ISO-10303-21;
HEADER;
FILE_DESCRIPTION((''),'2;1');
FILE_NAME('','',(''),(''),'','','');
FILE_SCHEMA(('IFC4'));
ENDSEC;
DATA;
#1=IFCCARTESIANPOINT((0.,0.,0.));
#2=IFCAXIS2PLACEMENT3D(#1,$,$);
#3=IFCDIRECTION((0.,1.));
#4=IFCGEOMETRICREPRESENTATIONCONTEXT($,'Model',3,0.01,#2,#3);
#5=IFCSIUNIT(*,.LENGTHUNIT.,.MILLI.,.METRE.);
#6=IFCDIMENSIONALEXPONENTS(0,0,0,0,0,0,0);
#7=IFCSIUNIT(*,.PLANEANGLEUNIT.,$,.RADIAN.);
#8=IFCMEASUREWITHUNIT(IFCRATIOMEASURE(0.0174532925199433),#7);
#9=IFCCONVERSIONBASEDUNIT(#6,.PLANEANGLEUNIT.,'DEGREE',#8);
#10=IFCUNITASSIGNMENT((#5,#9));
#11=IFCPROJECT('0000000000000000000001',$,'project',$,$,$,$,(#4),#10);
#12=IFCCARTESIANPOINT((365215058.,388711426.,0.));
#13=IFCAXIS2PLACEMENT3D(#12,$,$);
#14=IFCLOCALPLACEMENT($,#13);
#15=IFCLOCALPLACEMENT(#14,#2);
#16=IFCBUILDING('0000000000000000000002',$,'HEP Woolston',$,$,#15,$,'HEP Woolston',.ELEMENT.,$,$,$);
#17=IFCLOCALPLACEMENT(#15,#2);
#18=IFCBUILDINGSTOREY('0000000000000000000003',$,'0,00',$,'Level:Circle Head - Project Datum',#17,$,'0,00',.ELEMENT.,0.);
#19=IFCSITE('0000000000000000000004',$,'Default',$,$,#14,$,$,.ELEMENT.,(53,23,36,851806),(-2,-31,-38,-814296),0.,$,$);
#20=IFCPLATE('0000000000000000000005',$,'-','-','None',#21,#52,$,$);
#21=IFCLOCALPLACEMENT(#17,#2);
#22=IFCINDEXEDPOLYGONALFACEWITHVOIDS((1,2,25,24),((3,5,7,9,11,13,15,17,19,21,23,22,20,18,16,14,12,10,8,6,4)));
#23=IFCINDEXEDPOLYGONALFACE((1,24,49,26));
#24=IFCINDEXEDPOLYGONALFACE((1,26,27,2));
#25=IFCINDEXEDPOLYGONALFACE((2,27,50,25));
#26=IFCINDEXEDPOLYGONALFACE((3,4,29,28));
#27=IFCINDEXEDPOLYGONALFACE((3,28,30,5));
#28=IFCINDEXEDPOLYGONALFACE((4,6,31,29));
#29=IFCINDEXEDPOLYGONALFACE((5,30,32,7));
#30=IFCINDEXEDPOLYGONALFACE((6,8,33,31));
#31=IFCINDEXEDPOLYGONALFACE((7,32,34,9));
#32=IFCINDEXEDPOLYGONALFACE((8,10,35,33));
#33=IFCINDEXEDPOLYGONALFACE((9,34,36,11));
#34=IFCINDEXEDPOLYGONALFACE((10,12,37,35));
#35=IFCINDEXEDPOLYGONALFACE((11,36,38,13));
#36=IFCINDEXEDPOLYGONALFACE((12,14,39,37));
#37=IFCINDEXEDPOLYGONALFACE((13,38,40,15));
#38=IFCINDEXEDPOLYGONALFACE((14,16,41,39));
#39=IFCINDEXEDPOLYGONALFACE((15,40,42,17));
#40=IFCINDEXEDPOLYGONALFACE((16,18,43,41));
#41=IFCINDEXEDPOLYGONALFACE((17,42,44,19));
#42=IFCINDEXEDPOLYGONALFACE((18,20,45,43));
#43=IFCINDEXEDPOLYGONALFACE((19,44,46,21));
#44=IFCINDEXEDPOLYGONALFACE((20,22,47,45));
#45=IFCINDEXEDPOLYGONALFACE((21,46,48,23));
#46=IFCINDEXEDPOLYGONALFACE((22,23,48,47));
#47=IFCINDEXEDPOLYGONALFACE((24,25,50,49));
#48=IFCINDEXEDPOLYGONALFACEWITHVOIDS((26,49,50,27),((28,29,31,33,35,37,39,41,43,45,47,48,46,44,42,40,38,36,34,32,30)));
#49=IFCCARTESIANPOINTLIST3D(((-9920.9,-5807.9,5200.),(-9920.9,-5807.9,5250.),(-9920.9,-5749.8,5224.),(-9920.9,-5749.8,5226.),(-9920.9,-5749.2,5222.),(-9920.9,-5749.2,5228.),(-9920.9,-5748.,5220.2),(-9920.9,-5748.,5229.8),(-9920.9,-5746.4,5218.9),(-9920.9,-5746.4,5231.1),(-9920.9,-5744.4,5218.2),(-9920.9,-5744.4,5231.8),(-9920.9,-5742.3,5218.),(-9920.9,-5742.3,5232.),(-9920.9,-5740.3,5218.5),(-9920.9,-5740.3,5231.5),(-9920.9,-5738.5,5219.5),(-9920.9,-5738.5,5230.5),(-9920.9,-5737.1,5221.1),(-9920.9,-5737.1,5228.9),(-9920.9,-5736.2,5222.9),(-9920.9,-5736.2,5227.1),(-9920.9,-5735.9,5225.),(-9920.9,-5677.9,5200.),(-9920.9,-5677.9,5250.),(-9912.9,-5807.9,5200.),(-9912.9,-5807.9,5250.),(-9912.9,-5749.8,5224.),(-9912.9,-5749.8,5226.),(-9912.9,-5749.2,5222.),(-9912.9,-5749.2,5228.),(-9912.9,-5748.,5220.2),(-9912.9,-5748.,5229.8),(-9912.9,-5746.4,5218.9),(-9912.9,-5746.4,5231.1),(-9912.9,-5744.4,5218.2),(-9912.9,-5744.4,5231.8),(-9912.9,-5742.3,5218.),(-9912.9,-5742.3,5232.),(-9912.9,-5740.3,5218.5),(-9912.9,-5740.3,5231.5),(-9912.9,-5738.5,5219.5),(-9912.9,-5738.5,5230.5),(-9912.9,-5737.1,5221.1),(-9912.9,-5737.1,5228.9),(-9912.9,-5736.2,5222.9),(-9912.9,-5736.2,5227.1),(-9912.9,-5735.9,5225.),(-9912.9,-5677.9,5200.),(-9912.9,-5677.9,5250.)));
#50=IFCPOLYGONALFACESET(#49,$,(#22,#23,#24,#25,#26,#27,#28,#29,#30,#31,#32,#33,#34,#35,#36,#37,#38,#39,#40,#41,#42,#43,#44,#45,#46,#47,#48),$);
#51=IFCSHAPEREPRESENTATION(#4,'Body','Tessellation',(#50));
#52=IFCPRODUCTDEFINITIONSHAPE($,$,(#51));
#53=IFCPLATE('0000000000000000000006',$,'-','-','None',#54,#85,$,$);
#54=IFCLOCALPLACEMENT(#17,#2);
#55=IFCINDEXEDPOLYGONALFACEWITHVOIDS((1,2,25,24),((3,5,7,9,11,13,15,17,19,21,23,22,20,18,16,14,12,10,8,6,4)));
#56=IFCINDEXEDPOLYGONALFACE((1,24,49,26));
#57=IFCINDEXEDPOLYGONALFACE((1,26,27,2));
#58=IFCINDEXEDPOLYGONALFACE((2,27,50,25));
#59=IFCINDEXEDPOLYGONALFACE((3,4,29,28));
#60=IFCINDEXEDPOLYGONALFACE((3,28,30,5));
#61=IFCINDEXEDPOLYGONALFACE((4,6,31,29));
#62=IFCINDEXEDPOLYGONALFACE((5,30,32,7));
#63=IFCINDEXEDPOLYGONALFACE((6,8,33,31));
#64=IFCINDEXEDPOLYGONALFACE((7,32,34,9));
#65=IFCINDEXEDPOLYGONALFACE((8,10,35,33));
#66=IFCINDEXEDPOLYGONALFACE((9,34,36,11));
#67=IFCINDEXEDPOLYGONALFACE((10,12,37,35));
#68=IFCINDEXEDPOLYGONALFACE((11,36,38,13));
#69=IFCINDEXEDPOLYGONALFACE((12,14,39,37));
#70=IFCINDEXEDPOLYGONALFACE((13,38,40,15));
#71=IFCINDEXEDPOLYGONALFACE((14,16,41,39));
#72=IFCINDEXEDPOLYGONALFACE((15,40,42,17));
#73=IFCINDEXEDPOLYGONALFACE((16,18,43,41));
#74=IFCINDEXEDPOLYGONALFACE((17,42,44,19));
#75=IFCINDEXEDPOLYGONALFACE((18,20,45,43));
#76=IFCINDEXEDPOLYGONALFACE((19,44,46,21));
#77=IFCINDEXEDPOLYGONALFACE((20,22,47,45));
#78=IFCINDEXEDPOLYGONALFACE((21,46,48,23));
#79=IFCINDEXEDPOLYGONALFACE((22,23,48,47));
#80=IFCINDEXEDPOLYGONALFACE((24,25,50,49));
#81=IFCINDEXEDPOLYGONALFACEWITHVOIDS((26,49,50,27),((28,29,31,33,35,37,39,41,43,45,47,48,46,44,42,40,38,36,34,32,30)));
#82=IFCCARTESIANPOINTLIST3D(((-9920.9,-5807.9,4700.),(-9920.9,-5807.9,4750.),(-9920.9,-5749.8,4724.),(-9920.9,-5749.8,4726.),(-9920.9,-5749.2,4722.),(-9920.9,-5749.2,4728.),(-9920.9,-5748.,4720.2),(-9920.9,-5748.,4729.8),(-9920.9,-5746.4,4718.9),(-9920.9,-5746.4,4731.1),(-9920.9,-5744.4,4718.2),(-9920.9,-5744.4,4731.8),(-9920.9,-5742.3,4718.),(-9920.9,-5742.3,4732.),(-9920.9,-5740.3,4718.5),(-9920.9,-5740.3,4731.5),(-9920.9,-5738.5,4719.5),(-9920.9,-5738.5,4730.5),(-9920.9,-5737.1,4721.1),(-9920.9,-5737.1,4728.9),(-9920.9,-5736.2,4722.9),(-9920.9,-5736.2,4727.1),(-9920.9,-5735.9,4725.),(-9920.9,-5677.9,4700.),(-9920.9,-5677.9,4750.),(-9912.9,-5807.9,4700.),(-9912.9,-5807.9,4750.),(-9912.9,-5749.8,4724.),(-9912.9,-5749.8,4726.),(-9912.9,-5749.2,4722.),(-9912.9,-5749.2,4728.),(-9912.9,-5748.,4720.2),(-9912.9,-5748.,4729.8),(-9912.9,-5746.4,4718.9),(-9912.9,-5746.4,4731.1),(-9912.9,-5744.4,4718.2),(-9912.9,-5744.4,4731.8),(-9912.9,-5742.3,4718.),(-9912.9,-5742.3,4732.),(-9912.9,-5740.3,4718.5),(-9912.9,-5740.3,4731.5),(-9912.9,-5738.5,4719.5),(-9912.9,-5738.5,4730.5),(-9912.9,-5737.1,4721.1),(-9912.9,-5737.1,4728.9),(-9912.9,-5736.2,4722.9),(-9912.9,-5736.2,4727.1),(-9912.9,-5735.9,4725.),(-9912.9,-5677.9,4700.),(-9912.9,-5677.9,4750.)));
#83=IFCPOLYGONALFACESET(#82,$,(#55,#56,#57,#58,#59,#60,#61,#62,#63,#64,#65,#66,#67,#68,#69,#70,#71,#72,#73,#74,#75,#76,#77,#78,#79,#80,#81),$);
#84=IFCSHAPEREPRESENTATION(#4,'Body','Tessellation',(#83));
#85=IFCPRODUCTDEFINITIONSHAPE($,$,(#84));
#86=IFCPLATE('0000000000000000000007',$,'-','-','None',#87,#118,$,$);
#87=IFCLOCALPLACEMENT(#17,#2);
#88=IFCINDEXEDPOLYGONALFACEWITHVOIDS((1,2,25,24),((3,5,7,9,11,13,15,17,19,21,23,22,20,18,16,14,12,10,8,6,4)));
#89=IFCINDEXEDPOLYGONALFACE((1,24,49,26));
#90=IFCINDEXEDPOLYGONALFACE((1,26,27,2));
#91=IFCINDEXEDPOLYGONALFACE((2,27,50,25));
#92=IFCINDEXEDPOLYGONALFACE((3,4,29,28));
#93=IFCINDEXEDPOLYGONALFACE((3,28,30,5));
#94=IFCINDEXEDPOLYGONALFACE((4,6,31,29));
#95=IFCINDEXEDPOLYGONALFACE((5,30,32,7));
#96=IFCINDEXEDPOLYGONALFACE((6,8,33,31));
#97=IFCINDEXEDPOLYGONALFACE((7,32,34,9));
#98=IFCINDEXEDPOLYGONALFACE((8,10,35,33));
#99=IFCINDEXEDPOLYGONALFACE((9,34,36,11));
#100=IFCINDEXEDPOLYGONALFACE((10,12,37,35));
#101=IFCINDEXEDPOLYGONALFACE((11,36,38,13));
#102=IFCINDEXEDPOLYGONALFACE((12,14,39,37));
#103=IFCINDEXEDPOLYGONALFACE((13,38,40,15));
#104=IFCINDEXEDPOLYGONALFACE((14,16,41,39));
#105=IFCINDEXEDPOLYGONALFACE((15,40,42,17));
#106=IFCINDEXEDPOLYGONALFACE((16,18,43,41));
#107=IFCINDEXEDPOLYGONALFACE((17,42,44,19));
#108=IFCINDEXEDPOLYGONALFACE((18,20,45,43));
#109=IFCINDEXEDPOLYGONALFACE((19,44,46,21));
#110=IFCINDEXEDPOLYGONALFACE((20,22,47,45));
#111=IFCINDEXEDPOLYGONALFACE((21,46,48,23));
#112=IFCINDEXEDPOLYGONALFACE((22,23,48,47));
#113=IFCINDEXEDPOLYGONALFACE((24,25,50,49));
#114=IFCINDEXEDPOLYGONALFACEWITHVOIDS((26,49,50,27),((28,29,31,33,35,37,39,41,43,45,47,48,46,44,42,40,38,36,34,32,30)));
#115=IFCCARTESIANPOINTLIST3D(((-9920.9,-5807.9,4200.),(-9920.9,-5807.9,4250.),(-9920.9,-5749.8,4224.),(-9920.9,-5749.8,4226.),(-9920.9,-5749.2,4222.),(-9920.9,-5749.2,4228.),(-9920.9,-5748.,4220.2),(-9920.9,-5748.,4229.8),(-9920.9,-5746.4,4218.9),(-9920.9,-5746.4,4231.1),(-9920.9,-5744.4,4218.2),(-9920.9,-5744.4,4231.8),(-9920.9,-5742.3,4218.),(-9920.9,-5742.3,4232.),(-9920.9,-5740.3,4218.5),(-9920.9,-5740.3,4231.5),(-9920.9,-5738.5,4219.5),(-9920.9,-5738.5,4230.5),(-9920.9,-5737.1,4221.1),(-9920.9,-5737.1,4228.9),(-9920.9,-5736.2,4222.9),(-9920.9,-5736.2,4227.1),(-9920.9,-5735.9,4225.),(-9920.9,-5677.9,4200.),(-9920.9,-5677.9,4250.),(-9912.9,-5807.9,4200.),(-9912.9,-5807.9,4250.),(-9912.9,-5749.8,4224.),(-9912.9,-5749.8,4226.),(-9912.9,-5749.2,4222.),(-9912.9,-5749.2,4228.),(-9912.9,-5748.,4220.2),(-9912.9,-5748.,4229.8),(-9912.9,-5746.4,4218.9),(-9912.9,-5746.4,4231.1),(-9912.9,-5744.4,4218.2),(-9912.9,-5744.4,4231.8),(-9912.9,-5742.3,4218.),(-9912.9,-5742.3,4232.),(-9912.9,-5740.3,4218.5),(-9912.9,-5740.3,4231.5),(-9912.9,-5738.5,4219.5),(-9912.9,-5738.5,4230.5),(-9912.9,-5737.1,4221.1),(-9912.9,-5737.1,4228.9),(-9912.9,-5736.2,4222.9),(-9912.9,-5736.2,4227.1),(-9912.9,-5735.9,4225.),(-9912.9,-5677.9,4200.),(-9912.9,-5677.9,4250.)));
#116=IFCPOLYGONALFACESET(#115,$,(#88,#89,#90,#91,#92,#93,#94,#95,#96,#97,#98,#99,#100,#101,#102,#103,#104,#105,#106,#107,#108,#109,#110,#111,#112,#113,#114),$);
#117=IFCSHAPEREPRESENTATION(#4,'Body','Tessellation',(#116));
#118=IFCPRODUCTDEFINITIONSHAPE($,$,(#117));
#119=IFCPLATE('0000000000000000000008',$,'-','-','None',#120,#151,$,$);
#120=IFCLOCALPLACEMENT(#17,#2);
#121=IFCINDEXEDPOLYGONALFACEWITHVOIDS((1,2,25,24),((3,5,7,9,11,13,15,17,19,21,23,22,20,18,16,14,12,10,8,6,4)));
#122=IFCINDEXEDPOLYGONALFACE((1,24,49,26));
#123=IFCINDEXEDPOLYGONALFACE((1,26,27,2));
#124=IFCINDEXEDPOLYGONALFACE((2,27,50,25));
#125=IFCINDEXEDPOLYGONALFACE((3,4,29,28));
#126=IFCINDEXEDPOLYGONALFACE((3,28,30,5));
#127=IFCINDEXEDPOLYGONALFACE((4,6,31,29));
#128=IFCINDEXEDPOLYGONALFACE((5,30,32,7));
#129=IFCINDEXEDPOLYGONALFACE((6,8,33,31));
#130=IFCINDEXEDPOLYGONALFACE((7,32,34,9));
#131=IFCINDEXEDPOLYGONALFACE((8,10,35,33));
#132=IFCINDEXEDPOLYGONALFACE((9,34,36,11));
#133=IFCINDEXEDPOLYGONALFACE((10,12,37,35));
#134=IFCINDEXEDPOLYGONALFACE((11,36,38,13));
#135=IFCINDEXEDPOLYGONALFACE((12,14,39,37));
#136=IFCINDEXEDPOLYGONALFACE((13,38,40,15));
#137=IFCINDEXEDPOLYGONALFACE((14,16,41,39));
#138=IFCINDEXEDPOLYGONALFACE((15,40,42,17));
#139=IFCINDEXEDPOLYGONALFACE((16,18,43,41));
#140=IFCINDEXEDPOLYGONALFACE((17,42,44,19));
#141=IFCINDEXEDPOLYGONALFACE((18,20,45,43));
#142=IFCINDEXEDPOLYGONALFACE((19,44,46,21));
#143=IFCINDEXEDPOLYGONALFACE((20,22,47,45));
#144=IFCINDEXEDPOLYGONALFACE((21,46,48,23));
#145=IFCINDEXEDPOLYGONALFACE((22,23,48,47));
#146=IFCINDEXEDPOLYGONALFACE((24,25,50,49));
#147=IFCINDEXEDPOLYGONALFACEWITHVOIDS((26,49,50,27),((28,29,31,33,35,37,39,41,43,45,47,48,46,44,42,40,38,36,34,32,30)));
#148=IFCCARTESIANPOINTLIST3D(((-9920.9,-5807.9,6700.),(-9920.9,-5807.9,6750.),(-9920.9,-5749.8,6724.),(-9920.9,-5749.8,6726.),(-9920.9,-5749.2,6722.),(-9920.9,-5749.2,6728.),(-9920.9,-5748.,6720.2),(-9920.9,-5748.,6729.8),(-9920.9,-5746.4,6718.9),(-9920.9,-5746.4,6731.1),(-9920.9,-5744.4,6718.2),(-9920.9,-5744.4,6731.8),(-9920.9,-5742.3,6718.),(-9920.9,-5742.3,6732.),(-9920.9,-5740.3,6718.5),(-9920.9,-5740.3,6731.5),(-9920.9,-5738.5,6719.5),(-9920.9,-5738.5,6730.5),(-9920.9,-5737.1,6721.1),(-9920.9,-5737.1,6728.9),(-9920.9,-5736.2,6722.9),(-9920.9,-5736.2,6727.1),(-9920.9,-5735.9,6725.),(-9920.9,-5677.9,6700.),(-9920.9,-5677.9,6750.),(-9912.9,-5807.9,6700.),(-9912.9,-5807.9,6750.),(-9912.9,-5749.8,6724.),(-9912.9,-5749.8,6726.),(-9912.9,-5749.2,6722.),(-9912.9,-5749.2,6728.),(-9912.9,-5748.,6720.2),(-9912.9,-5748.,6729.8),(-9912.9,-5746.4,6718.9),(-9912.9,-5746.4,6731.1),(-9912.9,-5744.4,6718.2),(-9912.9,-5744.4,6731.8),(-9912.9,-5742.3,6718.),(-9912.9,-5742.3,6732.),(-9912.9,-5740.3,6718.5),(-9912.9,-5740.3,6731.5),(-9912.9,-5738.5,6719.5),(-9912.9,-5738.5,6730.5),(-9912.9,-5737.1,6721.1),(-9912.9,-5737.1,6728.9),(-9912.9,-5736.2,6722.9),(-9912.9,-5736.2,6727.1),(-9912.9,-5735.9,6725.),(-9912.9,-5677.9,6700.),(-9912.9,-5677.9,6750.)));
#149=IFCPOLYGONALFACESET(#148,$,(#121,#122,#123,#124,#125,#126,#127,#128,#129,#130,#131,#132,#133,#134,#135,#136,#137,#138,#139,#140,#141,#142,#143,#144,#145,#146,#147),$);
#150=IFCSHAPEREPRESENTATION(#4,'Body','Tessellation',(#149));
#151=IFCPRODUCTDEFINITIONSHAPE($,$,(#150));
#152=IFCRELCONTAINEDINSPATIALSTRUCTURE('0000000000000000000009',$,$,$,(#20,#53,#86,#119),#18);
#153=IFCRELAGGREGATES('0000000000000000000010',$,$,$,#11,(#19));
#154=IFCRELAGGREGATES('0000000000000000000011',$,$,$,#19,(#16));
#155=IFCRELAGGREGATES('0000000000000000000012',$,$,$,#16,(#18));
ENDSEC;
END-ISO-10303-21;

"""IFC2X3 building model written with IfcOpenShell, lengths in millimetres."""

from ifc_helpers import new_model, entity, si_unit, converted_unit, direction, frame, origin, origin_with_axes, origin_2d_with_axis, place, context, project, spatial, polyline, circle, outline, extrude, element, save


model = new_model("IFC2X3")

# Units and contexts
model_context = context("Model", 3, precision=0.01, world=origin(), true_north=direction((0.0, 1.0)))
ifc_project = project(units=[si_unit("LENGTHUNIT", "METRE", prefix="MILLI"), converted_unit("PLANEANGLEUNIT", "DEGREE", entity("IfcRatioMeasure", 0.0174532925199433), si_unit("PLANEANGLEUNIT", "RADIAN"), dimensions=[0, 0, 0, 0, 0, 0, 0])], contexts=[model_context])

# Site, building, storey
site_placement = place(None, frame((365215058.0, 388711426.0, 0.0)))
site = spatial("IfcSite", under=ifc_project, at=site_placement, Name="Default", CompositionType="ELEMENT", RefLatitude=(53, 23, 36, 851806), RefLongitude=(-2, -31, -38, -814296), RefElevation=0.0)
building_placement = place(site_placement, origin())
building = spatial("IfcBuilding", under=site, at=building_placement, Name="HEP Woolston", LongName="HEP Woolston", CompositionType="ELEMENT")
storey_placement = place(building_placement, origin())
storey = spatial("IfcBuildingStorey", under=building, at=storey_placement, Name="0,00", ObjectType="Level:Circle Head - Project Datum", LongName="0,00", CompositionType="ELEMENT", Elevation=0.0)

# Plates, openings
plate_1_placement = place(storey_placement, frame((-9920.9, -5807.9, 5250.0), z_axis=(1.0, 0.0, 0.0), x_axis=(0.0, 1.0, 0.0)))
plate_1 = element("IfcPlate", 1, at=plate_1_placement, inside=storey, Name="-", Description="-", ObjectType="None", context=model_context, shape_type="SweptSolid", body=[
    extrude(outline(polyline([(0.0, -50.0), (130.0, -50.0), (130.0, 0.0), (0.0, 0.0), (0.0, -50.0)])), origin_with_axes(), (0.0, 0.0, 1.0), 8.0),
])
opening_1_placement = place(plate_1_placement, frame((65.0, -25.0, 8.5), z_axis=(0.0, 0.0, -1.0), x_axis=(1.0, 0.0, 0.0)))
element("IfcOpeningElement", 2, at=opening_1_placement, cuts=plate_1, ObjectType="Opening", context=model_context, shape_type="SweptSolid", body=[
    extrude(circle(Radius=7.0, at=origin_2d_with_axis()), origin(), (0.0, 0.0, 1.0), 9.0),
])
plate_2_placement = place(storey_placement, frame((-9920.9, -5807.9, 4750.0), z_axis=(1.0, 0.0, 0.0), x_axis=(0.0, 1.0, 0.0)))
plate_2 = element("IfcPlate", 3, at=plate_2_placement, inside=storey, Name="-", Description="-", ObjectType="None", context=model_context, shape_type="SweptSolid", body=[
    extrude(outline(polyline([(0.0, -50.0), (130.0, -50.0), (130.0, 0.0), (0.0, 0.0), (0.0, -50.0)])), origin_with_axes(), (0.0, 0.0, 1.0), 8.0),
])
opening_2_placement = place(plate_2_placement, frame((65.0, -25.0, 8.5), z_axis=(0.0, 0.0, -1.0), x_axis=(1.0, 0.0, 0.0)))
element("IfcOpeningElement", 4, at=opening_2_placement, cuts=plate_2, ObjectType="Opening", context=model_context, shape_type="SweptSolid", body=[
    extrude(circle(Radius=7.0, at=origin_2d_with_axis()), origin(), (0.0, 0.0, 1.0), 9.0),
])
plate_3_placement = place(storey_placement, frame((-9920.9, -5807.9, 4250.0), z_axis=(1.0, 0.0, 0.0), x_axis=(0.0, 1.0, 0.0)))
plate_3 = element("IfcPlate", 5, at=plate_3_placement, inside=storey, Name="-", Description="-", ObjectType="None", context=model_context, shape_type="SweptSolid", body=[
    extrude(outline(polyline([(0.0, -50.0), (130.0, -50.0), (130.0, 0.0), (0.0, 0.0), (0.0, -50.0)])), origin_with_axes(), (0.0, 0.0, 1.0), 8.0),
])
opening_3_placement = place(plate_3_placement, frame((65.0, -25.0, 8.5), z_axis=(0.0, 0.0, -1.0), x_axis=(1.0, 0.0, 0.0)))
element("IfcOpeningElement", 6, at=opening_3_placement, cuts=plate_3, ObjectType="Opening", context=model_context, shape_type="SweptSolid", body=[
    extrude(circle(Radius=7.0, at=origin_2d_with_axis()), origin(), (0.0, 0.0, 1.0), 9.0),
])
plate_4_placement = place(storey_placement, frame((-9920.9, -5807.9, 6750.0), z_axis=(1.0, 0.0, 0.0), x_axis=(0.0, 1.0, 0.0)))
plate_4 = element("IfcPlate", 7, at=plate_4_placement, inside=storey, Name="-", Description="-", ObjectType="None", context=model_context, shape_type="SweptSolid", body=[
    extrude(outline(polyline([(0.0, -50.0), (130.0, -50.0), (130.0, 0.0), (0.0, 0.0), (0.0, -50.0)])), origin_with_axes(), (0.0, 0.0, 1.0), 8.0),
])
opening_4_placement = place(plate_4_placement, frame((65.0, -25.0, 8.5), z_axis=(0.0, 0.0, -1.0), x_axis=(1.0, 0.0, 0.0)))
element("IfcOpeningElement", 8, at=opening_4_placement, cuts=plate_4, ObjectType="Opening", context=model_context, shape_type="SweptSolid", body=[
    extrude(circle(Radius=7.0, at=origin_2d_with_axis()), origin(), (0.0, 0.0, 1.0), 9.0),
])

save(model, "model.ifc")
